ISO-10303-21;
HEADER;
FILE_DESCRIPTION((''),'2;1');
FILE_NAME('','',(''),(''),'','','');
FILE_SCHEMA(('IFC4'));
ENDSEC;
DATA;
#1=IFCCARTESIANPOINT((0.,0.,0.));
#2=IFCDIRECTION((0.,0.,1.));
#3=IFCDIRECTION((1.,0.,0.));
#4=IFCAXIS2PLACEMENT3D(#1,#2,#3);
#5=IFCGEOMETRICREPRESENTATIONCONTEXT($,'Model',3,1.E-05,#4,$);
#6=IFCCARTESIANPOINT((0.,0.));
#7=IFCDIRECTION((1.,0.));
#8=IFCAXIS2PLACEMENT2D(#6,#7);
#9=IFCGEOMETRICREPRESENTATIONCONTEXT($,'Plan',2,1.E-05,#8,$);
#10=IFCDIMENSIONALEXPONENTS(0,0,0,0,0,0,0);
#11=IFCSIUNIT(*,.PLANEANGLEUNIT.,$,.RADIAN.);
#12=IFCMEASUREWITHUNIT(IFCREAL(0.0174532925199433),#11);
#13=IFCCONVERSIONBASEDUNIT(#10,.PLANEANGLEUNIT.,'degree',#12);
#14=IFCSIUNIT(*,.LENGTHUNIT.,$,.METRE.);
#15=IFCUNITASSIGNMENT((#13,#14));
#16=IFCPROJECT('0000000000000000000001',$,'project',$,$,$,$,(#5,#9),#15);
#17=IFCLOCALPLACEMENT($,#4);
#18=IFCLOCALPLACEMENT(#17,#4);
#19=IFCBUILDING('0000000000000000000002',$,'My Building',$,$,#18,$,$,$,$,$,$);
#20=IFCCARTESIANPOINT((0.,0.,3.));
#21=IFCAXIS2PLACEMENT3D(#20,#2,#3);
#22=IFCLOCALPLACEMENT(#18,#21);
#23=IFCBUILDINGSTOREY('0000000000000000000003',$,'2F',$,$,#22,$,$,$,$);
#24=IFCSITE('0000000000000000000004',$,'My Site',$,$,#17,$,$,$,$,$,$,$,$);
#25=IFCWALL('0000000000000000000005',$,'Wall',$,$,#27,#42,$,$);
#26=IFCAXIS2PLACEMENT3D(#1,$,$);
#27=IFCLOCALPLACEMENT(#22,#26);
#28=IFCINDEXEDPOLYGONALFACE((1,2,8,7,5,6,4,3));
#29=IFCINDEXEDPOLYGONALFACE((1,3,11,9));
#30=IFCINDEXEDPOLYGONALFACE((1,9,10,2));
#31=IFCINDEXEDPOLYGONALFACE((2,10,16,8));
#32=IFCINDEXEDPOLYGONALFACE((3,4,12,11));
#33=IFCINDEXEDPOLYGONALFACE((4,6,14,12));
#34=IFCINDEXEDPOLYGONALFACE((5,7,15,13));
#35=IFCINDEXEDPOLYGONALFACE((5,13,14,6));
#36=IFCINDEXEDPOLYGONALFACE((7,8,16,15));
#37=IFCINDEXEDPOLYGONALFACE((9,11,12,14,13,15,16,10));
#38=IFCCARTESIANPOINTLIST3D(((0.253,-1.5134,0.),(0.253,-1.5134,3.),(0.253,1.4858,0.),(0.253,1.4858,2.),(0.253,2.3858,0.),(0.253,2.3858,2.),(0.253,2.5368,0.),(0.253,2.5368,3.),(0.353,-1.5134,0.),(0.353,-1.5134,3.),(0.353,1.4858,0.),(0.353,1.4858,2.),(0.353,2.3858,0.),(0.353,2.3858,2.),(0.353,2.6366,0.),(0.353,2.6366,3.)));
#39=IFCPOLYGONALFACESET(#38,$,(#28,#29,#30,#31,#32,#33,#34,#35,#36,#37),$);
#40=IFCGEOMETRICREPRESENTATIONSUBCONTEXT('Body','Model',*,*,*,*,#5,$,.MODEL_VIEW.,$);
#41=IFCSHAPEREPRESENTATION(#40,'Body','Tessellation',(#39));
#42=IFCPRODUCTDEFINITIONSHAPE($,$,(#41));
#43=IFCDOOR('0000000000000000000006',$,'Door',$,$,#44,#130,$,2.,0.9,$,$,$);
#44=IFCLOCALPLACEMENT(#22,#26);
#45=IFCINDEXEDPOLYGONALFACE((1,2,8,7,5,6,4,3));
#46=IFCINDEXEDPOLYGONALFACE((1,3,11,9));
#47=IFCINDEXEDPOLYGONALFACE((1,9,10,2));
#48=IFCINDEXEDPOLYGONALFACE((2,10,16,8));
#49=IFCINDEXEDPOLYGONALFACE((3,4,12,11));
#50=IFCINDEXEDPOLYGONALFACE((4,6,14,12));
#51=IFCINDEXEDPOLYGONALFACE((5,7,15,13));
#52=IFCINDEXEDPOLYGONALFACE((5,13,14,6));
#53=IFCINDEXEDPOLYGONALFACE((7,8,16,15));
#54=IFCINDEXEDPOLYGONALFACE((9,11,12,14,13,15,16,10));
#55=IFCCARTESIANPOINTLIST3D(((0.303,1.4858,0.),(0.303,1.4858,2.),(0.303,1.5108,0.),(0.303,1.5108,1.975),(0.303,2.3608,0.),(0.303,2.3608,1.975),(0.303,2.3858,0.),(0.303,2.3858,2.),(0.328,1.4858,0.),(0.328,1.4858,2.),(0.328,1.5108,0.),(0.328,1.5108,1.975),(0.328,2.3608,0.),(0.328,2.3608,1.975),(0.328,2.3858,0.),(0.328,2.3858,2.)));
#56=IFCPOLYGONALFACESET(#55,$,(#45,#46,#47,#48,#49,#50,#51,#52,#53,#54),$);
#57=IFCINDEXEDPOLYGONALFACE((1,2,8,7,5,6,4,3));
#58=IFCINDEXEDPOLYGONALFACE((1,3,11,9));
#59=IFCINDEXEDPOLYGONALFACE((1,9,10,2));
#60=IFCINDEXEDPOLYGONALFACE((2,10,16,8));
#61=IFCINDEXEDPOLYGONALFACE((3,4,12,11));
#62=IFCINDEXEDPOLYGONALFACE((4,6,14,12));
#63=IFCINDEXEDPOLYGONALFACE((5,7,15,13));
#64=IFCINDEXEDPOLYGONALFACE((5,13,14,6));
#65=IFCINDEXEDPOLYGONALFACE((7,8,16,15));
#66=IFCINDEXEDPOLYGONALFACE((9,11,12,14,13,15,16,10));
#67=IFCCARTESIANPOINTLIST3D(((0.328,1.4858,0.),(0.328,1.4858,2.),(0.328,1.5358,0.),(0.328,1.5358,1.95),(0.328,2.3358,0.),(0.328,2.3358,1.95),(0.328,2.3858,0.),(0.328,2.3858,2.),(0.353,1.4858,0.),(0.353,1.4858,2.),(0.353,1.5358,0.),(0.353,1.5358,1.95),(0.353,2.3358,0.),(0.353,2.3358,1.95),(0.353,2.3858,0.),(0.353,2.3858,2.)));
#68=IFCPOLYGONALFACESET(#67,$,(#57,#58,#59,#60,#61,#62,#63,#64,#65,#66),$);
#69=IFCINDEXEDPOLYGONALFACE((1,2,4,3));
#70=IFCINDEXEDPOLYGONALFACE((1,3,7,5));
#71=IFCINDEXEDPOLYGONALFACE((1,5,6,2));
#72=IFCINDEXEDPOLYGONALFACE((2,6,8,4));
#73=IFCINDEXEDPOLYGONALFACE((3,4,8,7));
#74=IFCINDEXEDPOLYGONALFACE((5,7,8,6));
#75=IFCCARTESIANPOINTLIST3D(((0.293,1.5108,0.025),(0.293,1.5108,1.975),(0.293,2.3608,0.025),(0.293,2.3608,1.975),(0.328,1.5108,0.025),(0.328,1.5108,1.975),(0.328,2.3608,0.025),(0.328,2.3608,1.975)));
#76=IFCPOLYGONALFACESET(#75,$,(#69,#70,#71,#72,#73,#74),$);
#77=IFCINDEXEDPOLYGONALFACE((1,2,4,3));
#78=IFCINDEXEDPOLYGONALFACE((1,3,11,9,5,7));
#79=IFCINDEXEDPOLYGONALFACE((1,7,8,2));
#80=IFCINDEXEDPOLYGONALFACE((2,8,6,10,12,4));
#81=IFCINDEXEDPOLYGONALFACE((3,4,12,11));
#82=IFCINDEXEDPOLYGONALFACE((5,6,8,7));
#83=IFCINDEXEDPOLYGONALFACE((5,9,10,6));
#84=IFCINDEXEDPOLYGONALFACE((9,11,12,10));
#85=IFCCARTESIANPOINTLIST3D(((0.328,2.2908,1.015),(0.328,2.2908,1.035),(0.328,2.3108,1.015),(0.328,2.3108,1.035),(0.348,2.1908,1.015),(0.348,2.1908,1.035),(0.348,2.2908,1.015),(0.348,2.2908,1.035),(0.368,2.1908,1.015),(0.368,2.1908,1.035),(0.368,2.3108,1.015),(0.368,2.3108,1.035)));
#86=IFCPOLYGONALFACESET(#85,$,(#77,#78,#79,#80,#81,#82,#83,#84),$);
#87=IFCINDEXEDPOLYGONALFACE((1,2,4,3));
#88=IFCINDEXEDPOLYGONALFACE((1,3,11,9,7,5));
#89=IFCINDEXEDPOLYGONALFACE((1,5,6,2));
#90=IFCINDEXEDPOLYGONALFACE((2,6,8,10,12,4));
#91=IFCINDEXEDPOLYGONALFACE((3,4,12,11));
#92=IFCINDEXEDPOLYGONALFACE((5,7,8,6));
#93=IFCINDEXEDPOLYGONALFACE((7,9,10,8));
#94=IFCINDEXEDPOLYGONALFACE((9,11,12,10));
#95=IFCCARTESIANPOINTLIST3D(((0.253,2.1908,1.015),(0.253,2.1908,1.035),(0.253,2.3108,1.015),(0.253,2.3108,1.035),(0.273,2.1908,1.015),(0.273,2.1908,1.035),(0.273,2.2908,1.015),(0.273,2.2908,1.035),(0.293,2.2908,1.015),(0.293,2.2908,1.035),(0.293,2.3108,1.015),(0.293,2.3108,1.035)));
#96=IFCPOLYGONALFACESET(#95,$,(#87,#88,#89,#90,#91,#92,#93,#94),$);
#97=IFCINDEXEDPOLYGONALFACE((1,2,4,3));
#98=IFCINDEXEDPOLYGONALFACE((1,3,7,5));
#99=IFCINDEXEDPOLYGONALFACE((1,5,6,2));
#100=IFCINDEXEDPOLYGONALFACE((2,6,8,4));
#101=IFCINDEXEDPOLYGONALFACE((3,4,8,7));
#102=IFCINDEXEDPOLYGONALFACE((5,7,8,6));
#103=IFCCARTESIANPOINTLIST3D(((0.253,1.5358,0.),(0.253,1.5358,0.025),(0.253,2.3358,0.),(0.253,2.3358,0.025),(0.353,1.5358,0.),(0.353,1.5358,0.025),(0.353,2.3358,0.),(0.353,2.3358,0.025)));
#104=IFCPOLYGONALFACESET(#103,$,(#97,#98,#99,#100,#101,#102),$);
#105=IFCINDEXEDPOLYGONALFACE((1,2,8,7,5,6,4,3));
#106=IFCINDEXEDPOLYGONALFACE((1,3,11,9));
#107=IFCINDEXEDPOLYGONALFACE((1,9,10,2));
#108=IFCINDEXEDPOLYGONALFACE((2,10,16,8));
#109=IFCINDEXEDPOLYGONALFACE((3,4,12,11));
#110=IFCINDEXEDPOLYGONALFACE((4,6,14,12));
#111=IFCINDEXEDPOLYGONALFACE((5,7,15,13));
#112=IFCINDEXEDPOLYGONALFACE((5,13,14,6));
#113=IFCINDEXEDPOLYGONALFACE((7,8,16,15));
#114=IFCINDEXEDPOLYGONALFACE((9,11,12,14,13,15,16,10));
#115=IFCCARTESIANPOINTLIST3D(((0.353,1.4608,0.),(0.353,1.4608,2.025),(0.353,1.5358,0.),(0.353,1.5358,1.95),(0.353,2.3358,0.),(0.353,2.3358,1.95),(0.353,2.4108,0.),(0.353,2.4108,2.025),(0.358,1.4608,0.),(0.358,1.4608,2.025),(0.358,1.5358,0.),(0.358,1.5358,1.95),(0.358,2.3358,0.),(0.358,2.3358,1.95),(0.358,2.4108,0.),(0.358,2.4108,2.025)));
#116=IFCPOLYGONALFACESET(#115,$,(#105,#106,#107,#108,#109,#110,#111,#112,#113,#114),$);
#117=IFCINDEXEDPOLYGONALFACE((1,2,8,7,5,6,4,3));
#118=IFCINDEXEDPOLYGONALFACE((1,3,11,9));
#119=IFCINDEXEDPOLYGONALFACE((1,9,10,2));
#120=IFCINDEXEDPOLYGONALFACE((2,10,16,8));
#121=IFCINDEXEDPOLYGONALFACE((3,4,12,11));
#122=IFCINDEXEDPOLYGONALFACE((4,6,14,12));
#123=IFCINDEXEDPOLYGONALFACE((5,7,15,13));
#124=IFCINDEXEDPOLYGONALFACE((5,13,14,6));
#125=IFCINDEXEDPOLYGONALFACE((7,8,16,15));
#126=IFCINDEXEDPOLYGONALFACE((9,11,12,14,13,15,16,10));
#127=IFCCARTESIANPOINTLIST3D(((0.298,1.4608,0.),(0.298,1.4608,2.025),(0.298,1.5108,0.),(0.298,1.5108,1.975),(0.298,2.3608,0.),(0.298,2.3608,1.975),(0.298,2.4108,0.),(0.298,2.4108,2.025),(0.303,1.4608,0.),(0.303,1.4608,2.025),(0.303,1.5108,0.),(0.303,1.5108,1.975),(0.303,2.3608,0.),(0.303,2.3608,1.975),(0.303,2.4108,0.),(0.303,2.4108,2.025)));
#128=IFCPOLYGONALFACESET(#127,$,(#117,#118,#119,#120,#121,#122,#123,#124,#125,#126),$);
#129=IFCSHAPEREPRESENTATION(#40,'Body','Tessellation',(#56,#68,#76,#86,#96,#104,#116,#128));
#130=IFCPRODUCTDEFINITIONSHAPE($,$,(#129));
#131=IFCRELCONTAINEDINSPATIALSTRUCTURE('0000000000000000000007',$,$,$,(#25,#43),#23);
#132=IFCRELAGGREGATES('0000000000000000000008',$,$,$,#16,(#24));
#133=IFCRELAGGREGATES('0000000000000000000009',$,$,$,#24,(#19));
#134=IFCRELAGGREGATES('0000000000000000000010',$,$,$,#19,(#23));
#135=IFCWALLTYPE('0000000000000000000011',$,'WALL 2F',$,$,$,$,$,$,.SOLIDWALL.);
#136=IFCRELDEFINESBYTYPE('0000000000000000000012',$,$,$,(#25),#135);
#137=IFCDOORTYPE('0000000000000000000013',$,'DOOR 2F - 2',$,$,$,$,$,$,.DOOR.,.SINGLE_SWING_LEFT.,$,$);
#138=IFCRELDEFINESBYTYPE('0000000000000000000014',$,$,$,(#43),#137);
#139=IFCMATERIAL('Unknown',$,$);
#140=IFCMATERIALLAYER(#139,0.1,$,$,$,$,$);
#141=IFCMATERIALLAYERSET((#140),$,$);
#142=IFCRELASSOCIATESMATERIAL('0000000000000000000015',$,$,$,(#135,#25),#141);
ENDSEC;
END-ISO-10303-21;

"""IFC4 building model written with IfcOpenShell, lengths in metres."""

from ifc_helpers import new_model, entity, si_unit, converted_unit, frame, origin_with_axes, origin_2d_with_axis, place, context, subcontext, project, spatial, line, indexed_curve, outline, extrude, shape, source, transform, mapped, material, layer, layer_set, layer_usage, type_object, type_shapes, element, fill, save


model = new_model("IFC4")

# Units and contexts
model_context = context("Model", 3, precision=1e-05, world=origin_with_axes())
plan_context = context("Plan", 2, precision=1e-05, world=origin_2d_with_axis())
body_context_1 = subcontext(model_context, "Body", "Model", "MODEL_VIEW")
body_context_2 = subcontext(plan_context, "Body", "Plan", "PLAN_VIEW")
ifc_project = project(units=[converted_unit("PLANEANGLEUNIT", "degree", entity("IfcReal", 0.0174532925199433), si_unit("PLANEANGLEUNIT", "RADIAN"), dimensions=[0, 0, 0, 0, 0, 0, 0]), si_unit("LENGTHUNIT", "METRE")], contexts=[model_context, plan_context])

# Site, building, storey
site_placement = place(None, origin_with_axes())
site = spatial("IfcSite", under=ifc_project, at=site_placement, Name="My Site")
building_placement = place(site_placement, origin_with_axes())
building = spatial("IfcBuilding", under=site, at=building_placement, Name="My Building")
storey_placement = place(building_placement, frame((0.0, 0.0, 3.0), z_axis=(0.0, 0.0, 1.0), x_axis=(1.0, 0.0, 0.0)))
storey = spatial("IfcBuildingStorey", under=building, at=storey_placement, Name="2F")

# Shared definitions
ifc_material = material(Name="Unknown")

# Shared definitions
ifc_layer = layer(ifc_material, 0.1)
ifc_layer_set = layer_set([ifc_layer])
wall_type = type_object("IfcWallType", Name="WALL 2F", PredefinedType="SOLIDWALL", material=ifc_layer_set)

# Wall, opening, door
ifc_layer_usage_1 = layer_usage(ifc_layer_set, "AXIS2", "POSITIVE", 0.0)
wall_1_placement = place(storey_placement, frame((0.353, -1.5134, 0.0), z_axis=(0.0, 0.0, 1.0), x_axis=(0.0, 1.0, 0.0)))
wall_1 = element("IfcWall", 1, at=wall_1_placement, inside=storey, type_object=wall_type, material=ifc_layer_usage_1, Name="Wall", context=body_context_1, shape_type="SweptSolid", body=[
    extrude(outline(indexed_curve([(0.0, 0.0), (0.0, 0.1), (4.0502, 0.1), (4.15, 0.0)], segments=[line(1, 2, 3, 4, 1)])), origin_with_axes(), (0.0, 0.0, 1.0), 3.0),
])
shared_shape_1 = source(origin_with_axes(), body_context_1, "Body", "SweptSolid", [
    extrude(outline(indexed_curve([(0.0, 0.0), (0.9, 0.0), (0.9, 2.0), (0.0, 2.0)], segments=[line(1, 2, 3, 4, 1)])), frame((0.0, -0.6, 0.0), z_axis=(0.0, -1.0, 0.0), x_axis=(1.0, 0.0, 0.0)), (0.0, 0.0, -1.0), 1.2),
])
opening_1_placement = place(wall_1_placement, frame((2.9992, 0.0, 0.0), z_axis=(0.0, 0.0, 1.0), x_axis=(1.0, 0.0, 0.0)))
opening_1 = element("IfcOpeningElement", 2, at=opening_1_placement, cuts=wall_1, PredefinedType="OPENING", context=body_context_1, shape_type="MappedRepresentation", body=[
    mapped(shared_shape_1, transform((0.0, 0.0, 0.0), x_axis=(1.0, 0.0, 0.0), y_axis=(0.0, 1.0, 0.0), z_axis=(0.0, 0.0, 1.0), scale=1.0)),
])
door_type_1 = type_object("IfcDoorType", Name="DOOR 2F - 2", OperationType="SINGLE_SWING_LEFT", PredefinedType="DOOR")
shared_shape_2 = source(origin_with_axes(), body_context_1, "Body", "SweptSolid", [
    extrude(outline(indexed_curve([(0.0, 0.0), (0.0, 2.0), (0.9, 2.0), (0.9, 0.0), (0.875, 0.0), (0.875, 1.975), (0.025, 1.975), (0.025, 0.0)], segments=[line(1, 2, 3, 4, 5, 6, 7, 8, 1)])), frame((0.0, 0.025, 0.0), z_axis=(0.0, -1.0, 0.0), x_axis=(1.0, 0.0, 0.0)), (0.0, 0.0, -1.0), 0.025),
    extrude(outline(indexed_curve([(0.0, 0.0), (0.0, 2.0), (0.9, 2.0), (0.9, 0.0), (0.85, 0.0), (0.85, 1.95), (0.05, 1.95), (0.05, 0.0)], segments=[line(1, 2, 3, 4, 5, 6, 7, 8, 1)])), frame((0.0, 0.0, 0.0), z_axis=(0.0, -1.0, 0.0), x_axis=(1.0, 0.0, 0.0)), (0.0, 0.0, -1.0), 0.025),
    extrude(outline(indexed_curve([(0.0, 0.0), (0.85, 0.0), (0.85, 0.035), (0.0, 0.035)], segments=[line(1, 2, 3, 4, 1)])), frame((0.025, 0.025, 0.025), z_axis=(0.0, 0.0, 1.0), x_axis=(1.0, 0.0, 0.0)), (0.0, 0.0, 1.0), 1.95),
    extrude(outline(indexed_curve([(0.0, 0.0), (0.0, -0.04), (-0.12, -0.04), (-0.12, -0.02), (-0.02, -0.02), (-0.02, 0.0)], segments=[line(1, 2, 3, 4, 5, 6, 1)])), frame((0.825, 0.025, 1.015), z_axis=(0.0, 0.0, 1.0), x_axis=(1.0, 0.0, 0.0)), (0.0, 0.0, 1.0), 0.02),
    extrude(outline(indexed_curve([(0.0, 0.0), (0.0, 0.04), (-0.12, 0.04), (-0.12, 0.02), (-0.02, 0.02), (-0.02, 0.0)], segments=[line(1, 2, 3, 4, 5, 6, 1)])), frame((0.825, 0.06, 1.015), z_axis=(0.0, 0.0, 1.0), x_axis=(1.0, 0.0, 0.0)), (0.0, 0.0, 1.0), 0.02),
    extrude(outline(indexed_curve([(0.0, 0.0), (0.8, 0.0), (0.8, 0.1), (0.0, 0.1)], segments=[line(1, 2, 3, 4, 1)])), frame((0.05, 0.0, 0.0), z_axis=(0.0, 0.0, 1.0), x_axis=(1.0, 0.0, 0.0)), (0.0, 0.0, 1.0), 0.025),
    extrude(outline(indexed_curve([(0.0, 0.0), (0.0, 2.025), (0.95, 2.025), (0.95, 0.0), (0.875, 0.0), (0.875, 1.95), (0.075, 1.95), (0.075, 0.0)], segments=[line(1, 2, 3, 4, 5, 6, 7, 8, 1)])), frame((-0.025, -0.005, 0.0), z_axis=(0.0, -1.0, 0.0), x_axis=(1.0, 0.0, 0.0)), (0.0, 0.0, -1.0), 0.005),
    extrude(outline(indexed_curve([(0.0, 0.0), (0.0, 2.025), (0.95, 2.025), (0.95, 0.0), (0.9, 0.0), (0.9, 1.975), (0.05, 1.975), (0.05, 0.0)], segments=[line(1, 2, 3, 4, 5, 6, 7, 8, 1)])), frame((-0.025, 0.05, 0.0), z_axis=(0.0, -1.0, 0.0), x_axis=(1.0, 0.0, 0.0)), (0.0, 0.0, -1.0), 0.005),
])
shared_shape_3 = source(origin_with_axes(), body_context_2, "Body", "Curve2D", [
    entity("IfcIndexedPolyCurve", entity("IfcCartesianPointList2D", [[0.0, 0.0], [0.0, 0.05], [0.025, 0.05], [0.025, 0.025], [0.05, 0.025], [0.05, 0.0]]), [entity("IfcLineIndex", [1, 2, 3, 4, 5, 6, 1])]),
    entity("IfcIndexedPolyCurve", entity("IfcCartesianPointList2D", [[0.9, 0.0], [0.9, 0.05], [0.875, 0.05], [0.875, 0.025], [0.85, 0.025], [0.85, 0.0]]), [entity("IfcLineIndex", [1, 2, 3, 4, 5, 6, 1])]),
    entity("IfcTrimmedCurve", entity("IfcEllipse", entity("IfcAxis2Placement2D", entity("IfcCartesianPoint", [0.06, 0.05]), entity("IfcDirection", [1.0, 0.0])), 0.815, 0.85), [entity("IfcCartesianPoint", [0.875, 0.05])], [entity("IfcCartesianPoint", [0.06, 0.9])], True, "CARTESIAN"),
    entity("IfcIndexedPolyCurve", entity("IfcCartesianPointList2D", [[0.025, 0.05], [0.06, 0.05], [0.06, 0.9], [0.025, 0.9]]), [entity("IfcLineIndex", [1, 2, 3, 4, 1])]),
])
type_shapes(door_type_1, [shared_shape_2, shared_shape_3])
door_1_placement = place(opening_1_placement, frame((0.0, 0.0, 0.0), z_axis=(0.0, 0.0, 1.0), x_axis=(1.0, 0.0, 0.0)))
door_1 = element("IfcDoor", 3, at=door_1_placement, inside=storey, type_object=door_type_1, Name="Door", OverallHeight=2.0, OverallWidth=0.9, shapes=[
    shape(body_context_1, "Body", "MappedRepresentation", [mapped(shared_shape_2, transform((0.0, 0.0, 0.0), x_axis=(1.0, 0.0, 0.0), y_axis=(0.0, 1.0, 0.0), z_axis=(0.0, 0.0, 1.0), scale=1.0))]),
    shape(body_context_2, "Body", "MappedRepresentation", [mapped(shared_shape_3, transform((0.0, 0.0, 0.0), x_axis=(1.0, 0.0, 0.0), y_axis=(0.0, 1.0, 0.0), z_axis=(0.0, 0.0, 1.0), scale=1.0))]),
])
fill(opening_1, door_1)

save(model, "model.ifc")
